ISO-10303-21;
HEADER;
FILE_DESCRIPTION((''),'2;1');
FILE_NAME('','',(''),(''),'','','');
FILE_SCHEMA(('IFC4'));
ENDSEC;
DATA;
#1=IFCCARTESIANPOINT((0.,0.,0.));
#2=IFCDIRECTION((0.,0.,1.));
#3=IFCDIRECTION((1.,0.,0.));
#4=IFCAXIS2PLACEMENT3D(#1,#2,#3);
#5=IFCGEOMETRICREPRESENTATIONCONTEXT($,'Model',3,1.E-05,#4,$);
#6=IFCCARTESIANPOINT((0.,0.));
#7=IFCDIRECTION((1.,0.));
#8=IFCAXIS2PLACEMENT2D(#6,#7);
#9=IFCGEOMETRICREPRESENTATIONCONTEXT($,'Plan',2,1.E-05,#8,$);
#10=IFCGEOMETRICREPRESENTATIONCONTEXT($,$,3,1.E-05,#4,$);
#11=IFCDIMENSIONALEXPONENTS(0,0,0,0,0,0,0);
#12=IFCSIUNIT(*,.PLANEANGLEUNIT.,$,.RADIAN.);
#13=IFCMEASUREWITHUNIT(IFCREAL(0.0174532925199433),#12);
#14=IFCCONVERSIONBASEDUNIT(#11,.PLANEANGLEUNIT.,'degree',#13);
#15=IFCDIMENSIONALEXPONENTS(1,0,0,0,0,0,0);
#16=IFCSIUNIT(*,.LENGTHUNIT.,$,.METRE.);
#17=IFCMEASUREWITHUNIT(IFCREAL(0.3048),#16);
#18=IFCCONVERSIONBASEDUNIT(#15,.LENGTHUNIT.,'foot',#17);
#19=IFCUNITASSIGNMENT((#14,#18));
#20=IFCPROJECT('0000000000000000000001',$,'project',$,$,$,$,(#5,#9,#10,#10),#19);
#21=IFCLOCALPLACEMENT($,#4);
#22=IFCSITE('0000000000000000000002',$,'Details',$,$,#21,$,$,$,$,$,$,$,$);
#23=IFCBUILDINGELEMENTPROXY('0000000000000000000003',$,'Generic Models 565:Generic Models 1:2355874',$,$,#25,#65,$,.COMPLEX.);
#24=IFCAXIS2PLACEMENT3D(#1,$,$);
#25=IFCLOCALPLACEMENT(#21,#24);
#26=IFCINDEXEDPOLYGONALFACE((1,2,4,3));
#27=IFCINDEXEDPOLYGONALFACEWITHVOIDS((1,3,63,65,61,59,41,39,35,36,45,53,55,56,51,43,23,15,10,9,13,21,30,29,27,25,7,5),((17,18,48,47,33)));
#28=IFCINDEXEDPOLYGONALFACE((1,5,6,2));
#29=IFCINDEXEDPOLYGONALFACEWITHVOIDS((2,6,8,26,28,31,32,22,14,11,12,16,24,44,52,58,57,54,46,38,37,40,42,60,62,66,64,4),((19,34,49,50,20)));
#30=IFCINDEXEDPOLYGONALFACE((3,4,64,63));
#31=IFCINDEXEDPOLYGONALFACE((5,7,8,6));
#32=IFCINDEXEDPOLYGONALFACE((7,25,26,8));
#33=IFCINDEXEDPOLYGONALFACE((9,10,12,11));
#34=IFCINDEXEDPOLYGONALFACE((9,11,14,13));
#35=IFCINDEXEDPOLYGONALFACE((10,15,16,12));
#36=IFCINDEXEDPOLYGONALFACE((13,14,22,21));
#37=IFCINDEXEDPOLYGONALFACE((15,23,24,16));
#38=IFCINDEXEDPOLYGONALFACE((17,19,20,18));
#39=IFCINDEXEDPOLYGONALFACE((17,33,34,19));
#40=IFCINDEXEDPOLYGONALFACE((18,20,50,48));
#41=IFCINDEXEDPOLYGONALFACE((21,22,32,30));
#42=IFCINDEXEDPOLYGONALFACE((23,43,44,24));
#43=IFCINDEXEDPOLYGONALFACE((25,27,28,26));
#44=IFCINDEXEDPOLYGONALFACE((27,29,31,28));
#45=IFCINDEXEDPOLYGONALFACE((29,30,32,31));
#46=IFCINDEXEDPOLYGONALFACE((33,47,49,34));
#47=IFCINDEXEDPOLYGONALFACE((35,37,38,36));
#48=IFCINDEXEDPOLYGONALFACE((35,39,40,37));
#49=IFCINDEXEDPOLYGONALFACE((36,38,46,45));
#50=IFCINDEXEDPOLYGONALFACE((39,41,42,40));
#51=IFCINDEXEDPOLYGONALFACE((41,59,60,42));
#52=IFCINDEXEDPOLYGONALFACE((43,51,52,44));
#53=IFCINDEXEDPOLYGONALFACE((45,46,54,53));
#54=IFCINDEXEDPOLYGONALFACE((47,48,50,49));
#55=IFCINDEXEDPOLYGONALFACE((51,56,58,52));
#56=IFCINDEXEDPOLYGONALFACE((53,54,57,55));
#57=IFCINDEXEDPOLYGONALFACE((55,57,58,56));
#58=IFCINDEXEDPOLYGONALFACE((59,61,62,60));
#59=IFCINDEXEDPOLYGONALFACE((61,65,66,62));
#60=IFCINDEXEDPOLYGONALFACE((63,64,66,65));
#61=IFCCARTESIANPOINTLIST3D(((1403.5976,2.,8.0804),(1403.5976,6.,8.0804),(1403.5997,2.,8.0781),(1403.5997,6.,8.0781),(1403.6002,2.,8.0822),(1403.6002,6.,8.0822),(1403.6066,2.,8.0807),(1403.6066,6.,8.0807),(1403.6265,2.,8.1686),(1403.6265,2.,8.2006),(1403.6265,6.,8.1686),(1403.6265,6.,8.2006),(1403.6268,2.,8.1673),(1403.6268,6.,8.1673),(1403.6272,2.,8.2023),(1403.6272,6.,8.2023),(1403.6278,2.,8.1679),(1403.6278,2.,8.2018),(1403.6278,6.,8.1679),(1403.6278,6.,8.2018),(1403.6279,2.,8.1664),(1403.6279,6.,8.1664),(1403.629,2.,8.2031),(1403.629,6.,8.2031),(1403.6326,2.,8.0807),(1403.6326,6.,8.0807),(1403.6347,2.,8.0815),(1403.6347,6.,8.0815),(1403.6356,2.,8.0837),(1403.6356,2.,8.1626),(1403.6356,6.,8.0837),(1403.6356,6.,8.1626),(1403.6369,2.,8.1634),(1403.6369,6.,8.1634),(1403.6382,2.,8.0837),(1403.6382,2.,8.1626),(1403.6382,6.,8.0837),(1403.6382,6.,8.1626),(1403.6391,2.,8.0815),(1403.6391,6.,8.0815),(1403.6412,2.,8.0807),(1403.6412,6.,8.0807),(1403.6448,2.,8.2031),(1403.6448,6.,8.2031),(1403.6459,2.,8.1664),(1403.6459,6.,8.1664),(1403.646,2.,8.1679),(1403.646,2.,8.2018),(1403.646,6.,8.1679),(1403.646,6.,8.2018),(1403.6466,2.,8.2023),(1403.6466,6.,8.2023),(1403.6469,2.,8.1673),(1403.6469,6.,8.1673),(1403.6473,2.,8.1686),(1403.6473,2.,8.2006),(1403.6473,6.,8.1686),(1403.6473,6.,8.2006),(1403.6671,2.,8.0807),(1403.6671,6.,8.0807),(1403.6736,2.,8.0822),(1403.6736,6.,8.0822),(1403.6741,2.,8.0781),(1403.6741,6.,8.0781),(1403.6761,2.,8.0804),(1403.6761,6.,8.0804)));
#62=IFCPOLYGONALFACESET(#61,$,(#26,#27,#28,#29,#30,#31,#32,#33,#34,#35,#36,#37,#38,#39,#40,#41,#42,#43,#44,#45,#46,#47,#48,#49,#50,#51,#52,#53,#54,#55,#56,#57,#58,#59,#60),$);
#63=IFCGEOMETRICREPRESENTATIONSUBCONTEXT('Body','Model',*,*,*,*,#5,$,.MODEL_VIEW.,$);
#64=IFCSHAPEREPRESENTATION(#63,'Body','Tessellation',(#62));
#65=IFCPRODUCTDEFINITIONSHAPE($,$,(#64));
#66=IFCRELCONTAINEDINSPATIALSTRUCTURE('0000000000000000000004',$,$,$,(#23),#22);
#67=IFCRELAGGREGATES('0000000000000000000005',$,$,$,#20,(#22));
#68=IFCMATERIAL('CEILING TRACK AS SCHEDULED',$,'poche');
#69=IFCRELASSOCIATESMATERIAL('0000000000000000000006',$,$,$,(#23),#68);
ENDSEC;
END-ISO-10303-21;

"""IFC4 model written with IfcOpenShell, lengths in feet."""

from ifc_helpers import new_model, entity, si_unit, converted_unit, frame, origin_with_axes, origin_2d_with_axis, place, context, subcontext, project, spatial, line, indexed_curve, outline, extrude, material, element, save


model = new_model("IFC4")

# Units and contexts
model_context = context("Model", 3, precision=1e-05, world=origin_with_axes())
plan_context = context("Plan", 2, precision=1e-05, world=origin_2d_with_axis())
context_of_model = context(None, 3, precision=1e-05, world=origin_with_axes())
body_context = subcontext(model_context, "Body", "Model", "MODEL_VIEW")
ifc_project = project(units=[converted_unit("PLANEANGLEUNIT", "degree", entity("IfcReal", 0.0174532925199433), si_unit("PLANEANGLEUNIT", "RADIAN"), dimensions=[0, 0, 0, 0, 0, 0, 0]), converted_unit("LENGTHUNIT", "foot", entity("IfcReal", 0.3048), si_unit("LENGTHUNIT", "METRE"), dimensions=[1, 0, 0, 0, 0, 0, 0])], contexts=[model_context, plan_context, context_of_model, context_of_model])

# Site
site_placement = place(None, origin_with_axes())
site = spatial("IfcSite", under=ifc_project, at=site_placement, Name="Details")

# Building element proxy
ifc_material_1 = material(Name="CEILING TRACK AS SCHEDULED", Category="poche")
proxy_1_placement = place(site_placement, frame((1403.5976, 6.0, 8.0781), z_axis=(0.0, -1.0, 0.0), x_axis=(0.0, 0.0, 1.0)))
element("IfcBuildingElementProxy", 1, at=proxy_1_placement, inside=site, material=ifc_material_1, Name="Generic Models 565:Generic Models 1:2355874", PredefinedType="COMPLEX", context=body_context, shape_type="SweptSolid", body=[
    extrude(outline(indexed_curve([(0.0297, 0.0058), (0.0311, 0.006), (0.0627, 0.0015), (0.0643, 0.0005), (0.0648, -0.0014), (0.0625, -0.017), (0.0615, -0.0187), (0.0597, -0.0192), (0.0281, -0.0146), (0.0268, -0.014), (0.0261, -0.0129), (0.0234, -0.0047), (-0.0547, 0.0066), (-0.0569, 0.006), (-0.0581, 0.0041), (-0.0618, -0.0216), (-0.0612, -0.0282), (-0.0634, -0.0305), (-0.0654, -0.0281), (-0.0547, 0.0455), (-0.0522, 0.0472), (-0.0507, 0.0444), (-0.0532, 0.0382), (-0.0569, 0.0126), (-0.0563, 0.0103), (-0.0543, 0.0092), (0.0238, -0.0021), (0.0286, 0.005), (0.0301, 0.0048), (0.0637, 0.0), (0.0611, -0.018), (0.0275, -0.0132), (0.0244, -0.0035)], segments=[line(7, 6), line(6, 5), line(5, 4), line(4, 3), line(3, 2), line(2, 1), line(1, 28), line(28, 27), line(27, 26), line(26, 25), line(25, 24), line(24, 23), line(23, 22), line(22, 21), line(21, 20), line(20, 19), line(19, 18), line(18, 17), line(17, 16), line(16, 15), line(15, 14), line(14, 13), line(13, 12), line(12, 11), line(11, 10), line(10, 9), line(9, 8), line(8, 7)], self_intersect=False), holes=[indexed_curve([(0.0297, 0.0058), (0.0311, 0.006), (0.0627, 0.0015), (0.0643, 0.0005), (0.0648, -0.0014), (0.0625, -0.017), (0.0615, -0.0187), (0.0597, -0.0192), (0.0281, -0.0146), (0.0268, -0.014), (0.0261, -0.0129), (0.0234, -0.0047), (-0.0547, 0.0066), (-0.0569, 0.006), (-0.0581, 0.0041), (-0.0618, -0.0216), (-0.0612, -0.0282), (-0.0634, -0.0305), (-0.0654, -0.0281), (-0.0547, 0.0455), (-0.0522, 0.0472), (-0.0507, 0.0444), (-0.0532, 0.0382), (-0.0569, 0.0126), (-0.0563, 0.0103), (-0.0543, 0.0092), (0.0238, -0.0021), (0.0286, 0.005), (0.0301, 0.0048), (0.0637, 0.0), (0.0611, -0.018), (0.0275, -0.0132), (0.0244, -0.0035)], segments=[line(31, 32), line(32, 33), line(33, 29), line(29, 30), line(30, 31)], self_intersect=False)]), frame((0.0607, -0.0392, 0.0), z_axis=(0.0, 0.0, -1.0), x_axis=(0.989698, -0.14317, 0.0)), (0.0, 0.0, -1.0), 4.0),
])

save(model, "model.ifc")
